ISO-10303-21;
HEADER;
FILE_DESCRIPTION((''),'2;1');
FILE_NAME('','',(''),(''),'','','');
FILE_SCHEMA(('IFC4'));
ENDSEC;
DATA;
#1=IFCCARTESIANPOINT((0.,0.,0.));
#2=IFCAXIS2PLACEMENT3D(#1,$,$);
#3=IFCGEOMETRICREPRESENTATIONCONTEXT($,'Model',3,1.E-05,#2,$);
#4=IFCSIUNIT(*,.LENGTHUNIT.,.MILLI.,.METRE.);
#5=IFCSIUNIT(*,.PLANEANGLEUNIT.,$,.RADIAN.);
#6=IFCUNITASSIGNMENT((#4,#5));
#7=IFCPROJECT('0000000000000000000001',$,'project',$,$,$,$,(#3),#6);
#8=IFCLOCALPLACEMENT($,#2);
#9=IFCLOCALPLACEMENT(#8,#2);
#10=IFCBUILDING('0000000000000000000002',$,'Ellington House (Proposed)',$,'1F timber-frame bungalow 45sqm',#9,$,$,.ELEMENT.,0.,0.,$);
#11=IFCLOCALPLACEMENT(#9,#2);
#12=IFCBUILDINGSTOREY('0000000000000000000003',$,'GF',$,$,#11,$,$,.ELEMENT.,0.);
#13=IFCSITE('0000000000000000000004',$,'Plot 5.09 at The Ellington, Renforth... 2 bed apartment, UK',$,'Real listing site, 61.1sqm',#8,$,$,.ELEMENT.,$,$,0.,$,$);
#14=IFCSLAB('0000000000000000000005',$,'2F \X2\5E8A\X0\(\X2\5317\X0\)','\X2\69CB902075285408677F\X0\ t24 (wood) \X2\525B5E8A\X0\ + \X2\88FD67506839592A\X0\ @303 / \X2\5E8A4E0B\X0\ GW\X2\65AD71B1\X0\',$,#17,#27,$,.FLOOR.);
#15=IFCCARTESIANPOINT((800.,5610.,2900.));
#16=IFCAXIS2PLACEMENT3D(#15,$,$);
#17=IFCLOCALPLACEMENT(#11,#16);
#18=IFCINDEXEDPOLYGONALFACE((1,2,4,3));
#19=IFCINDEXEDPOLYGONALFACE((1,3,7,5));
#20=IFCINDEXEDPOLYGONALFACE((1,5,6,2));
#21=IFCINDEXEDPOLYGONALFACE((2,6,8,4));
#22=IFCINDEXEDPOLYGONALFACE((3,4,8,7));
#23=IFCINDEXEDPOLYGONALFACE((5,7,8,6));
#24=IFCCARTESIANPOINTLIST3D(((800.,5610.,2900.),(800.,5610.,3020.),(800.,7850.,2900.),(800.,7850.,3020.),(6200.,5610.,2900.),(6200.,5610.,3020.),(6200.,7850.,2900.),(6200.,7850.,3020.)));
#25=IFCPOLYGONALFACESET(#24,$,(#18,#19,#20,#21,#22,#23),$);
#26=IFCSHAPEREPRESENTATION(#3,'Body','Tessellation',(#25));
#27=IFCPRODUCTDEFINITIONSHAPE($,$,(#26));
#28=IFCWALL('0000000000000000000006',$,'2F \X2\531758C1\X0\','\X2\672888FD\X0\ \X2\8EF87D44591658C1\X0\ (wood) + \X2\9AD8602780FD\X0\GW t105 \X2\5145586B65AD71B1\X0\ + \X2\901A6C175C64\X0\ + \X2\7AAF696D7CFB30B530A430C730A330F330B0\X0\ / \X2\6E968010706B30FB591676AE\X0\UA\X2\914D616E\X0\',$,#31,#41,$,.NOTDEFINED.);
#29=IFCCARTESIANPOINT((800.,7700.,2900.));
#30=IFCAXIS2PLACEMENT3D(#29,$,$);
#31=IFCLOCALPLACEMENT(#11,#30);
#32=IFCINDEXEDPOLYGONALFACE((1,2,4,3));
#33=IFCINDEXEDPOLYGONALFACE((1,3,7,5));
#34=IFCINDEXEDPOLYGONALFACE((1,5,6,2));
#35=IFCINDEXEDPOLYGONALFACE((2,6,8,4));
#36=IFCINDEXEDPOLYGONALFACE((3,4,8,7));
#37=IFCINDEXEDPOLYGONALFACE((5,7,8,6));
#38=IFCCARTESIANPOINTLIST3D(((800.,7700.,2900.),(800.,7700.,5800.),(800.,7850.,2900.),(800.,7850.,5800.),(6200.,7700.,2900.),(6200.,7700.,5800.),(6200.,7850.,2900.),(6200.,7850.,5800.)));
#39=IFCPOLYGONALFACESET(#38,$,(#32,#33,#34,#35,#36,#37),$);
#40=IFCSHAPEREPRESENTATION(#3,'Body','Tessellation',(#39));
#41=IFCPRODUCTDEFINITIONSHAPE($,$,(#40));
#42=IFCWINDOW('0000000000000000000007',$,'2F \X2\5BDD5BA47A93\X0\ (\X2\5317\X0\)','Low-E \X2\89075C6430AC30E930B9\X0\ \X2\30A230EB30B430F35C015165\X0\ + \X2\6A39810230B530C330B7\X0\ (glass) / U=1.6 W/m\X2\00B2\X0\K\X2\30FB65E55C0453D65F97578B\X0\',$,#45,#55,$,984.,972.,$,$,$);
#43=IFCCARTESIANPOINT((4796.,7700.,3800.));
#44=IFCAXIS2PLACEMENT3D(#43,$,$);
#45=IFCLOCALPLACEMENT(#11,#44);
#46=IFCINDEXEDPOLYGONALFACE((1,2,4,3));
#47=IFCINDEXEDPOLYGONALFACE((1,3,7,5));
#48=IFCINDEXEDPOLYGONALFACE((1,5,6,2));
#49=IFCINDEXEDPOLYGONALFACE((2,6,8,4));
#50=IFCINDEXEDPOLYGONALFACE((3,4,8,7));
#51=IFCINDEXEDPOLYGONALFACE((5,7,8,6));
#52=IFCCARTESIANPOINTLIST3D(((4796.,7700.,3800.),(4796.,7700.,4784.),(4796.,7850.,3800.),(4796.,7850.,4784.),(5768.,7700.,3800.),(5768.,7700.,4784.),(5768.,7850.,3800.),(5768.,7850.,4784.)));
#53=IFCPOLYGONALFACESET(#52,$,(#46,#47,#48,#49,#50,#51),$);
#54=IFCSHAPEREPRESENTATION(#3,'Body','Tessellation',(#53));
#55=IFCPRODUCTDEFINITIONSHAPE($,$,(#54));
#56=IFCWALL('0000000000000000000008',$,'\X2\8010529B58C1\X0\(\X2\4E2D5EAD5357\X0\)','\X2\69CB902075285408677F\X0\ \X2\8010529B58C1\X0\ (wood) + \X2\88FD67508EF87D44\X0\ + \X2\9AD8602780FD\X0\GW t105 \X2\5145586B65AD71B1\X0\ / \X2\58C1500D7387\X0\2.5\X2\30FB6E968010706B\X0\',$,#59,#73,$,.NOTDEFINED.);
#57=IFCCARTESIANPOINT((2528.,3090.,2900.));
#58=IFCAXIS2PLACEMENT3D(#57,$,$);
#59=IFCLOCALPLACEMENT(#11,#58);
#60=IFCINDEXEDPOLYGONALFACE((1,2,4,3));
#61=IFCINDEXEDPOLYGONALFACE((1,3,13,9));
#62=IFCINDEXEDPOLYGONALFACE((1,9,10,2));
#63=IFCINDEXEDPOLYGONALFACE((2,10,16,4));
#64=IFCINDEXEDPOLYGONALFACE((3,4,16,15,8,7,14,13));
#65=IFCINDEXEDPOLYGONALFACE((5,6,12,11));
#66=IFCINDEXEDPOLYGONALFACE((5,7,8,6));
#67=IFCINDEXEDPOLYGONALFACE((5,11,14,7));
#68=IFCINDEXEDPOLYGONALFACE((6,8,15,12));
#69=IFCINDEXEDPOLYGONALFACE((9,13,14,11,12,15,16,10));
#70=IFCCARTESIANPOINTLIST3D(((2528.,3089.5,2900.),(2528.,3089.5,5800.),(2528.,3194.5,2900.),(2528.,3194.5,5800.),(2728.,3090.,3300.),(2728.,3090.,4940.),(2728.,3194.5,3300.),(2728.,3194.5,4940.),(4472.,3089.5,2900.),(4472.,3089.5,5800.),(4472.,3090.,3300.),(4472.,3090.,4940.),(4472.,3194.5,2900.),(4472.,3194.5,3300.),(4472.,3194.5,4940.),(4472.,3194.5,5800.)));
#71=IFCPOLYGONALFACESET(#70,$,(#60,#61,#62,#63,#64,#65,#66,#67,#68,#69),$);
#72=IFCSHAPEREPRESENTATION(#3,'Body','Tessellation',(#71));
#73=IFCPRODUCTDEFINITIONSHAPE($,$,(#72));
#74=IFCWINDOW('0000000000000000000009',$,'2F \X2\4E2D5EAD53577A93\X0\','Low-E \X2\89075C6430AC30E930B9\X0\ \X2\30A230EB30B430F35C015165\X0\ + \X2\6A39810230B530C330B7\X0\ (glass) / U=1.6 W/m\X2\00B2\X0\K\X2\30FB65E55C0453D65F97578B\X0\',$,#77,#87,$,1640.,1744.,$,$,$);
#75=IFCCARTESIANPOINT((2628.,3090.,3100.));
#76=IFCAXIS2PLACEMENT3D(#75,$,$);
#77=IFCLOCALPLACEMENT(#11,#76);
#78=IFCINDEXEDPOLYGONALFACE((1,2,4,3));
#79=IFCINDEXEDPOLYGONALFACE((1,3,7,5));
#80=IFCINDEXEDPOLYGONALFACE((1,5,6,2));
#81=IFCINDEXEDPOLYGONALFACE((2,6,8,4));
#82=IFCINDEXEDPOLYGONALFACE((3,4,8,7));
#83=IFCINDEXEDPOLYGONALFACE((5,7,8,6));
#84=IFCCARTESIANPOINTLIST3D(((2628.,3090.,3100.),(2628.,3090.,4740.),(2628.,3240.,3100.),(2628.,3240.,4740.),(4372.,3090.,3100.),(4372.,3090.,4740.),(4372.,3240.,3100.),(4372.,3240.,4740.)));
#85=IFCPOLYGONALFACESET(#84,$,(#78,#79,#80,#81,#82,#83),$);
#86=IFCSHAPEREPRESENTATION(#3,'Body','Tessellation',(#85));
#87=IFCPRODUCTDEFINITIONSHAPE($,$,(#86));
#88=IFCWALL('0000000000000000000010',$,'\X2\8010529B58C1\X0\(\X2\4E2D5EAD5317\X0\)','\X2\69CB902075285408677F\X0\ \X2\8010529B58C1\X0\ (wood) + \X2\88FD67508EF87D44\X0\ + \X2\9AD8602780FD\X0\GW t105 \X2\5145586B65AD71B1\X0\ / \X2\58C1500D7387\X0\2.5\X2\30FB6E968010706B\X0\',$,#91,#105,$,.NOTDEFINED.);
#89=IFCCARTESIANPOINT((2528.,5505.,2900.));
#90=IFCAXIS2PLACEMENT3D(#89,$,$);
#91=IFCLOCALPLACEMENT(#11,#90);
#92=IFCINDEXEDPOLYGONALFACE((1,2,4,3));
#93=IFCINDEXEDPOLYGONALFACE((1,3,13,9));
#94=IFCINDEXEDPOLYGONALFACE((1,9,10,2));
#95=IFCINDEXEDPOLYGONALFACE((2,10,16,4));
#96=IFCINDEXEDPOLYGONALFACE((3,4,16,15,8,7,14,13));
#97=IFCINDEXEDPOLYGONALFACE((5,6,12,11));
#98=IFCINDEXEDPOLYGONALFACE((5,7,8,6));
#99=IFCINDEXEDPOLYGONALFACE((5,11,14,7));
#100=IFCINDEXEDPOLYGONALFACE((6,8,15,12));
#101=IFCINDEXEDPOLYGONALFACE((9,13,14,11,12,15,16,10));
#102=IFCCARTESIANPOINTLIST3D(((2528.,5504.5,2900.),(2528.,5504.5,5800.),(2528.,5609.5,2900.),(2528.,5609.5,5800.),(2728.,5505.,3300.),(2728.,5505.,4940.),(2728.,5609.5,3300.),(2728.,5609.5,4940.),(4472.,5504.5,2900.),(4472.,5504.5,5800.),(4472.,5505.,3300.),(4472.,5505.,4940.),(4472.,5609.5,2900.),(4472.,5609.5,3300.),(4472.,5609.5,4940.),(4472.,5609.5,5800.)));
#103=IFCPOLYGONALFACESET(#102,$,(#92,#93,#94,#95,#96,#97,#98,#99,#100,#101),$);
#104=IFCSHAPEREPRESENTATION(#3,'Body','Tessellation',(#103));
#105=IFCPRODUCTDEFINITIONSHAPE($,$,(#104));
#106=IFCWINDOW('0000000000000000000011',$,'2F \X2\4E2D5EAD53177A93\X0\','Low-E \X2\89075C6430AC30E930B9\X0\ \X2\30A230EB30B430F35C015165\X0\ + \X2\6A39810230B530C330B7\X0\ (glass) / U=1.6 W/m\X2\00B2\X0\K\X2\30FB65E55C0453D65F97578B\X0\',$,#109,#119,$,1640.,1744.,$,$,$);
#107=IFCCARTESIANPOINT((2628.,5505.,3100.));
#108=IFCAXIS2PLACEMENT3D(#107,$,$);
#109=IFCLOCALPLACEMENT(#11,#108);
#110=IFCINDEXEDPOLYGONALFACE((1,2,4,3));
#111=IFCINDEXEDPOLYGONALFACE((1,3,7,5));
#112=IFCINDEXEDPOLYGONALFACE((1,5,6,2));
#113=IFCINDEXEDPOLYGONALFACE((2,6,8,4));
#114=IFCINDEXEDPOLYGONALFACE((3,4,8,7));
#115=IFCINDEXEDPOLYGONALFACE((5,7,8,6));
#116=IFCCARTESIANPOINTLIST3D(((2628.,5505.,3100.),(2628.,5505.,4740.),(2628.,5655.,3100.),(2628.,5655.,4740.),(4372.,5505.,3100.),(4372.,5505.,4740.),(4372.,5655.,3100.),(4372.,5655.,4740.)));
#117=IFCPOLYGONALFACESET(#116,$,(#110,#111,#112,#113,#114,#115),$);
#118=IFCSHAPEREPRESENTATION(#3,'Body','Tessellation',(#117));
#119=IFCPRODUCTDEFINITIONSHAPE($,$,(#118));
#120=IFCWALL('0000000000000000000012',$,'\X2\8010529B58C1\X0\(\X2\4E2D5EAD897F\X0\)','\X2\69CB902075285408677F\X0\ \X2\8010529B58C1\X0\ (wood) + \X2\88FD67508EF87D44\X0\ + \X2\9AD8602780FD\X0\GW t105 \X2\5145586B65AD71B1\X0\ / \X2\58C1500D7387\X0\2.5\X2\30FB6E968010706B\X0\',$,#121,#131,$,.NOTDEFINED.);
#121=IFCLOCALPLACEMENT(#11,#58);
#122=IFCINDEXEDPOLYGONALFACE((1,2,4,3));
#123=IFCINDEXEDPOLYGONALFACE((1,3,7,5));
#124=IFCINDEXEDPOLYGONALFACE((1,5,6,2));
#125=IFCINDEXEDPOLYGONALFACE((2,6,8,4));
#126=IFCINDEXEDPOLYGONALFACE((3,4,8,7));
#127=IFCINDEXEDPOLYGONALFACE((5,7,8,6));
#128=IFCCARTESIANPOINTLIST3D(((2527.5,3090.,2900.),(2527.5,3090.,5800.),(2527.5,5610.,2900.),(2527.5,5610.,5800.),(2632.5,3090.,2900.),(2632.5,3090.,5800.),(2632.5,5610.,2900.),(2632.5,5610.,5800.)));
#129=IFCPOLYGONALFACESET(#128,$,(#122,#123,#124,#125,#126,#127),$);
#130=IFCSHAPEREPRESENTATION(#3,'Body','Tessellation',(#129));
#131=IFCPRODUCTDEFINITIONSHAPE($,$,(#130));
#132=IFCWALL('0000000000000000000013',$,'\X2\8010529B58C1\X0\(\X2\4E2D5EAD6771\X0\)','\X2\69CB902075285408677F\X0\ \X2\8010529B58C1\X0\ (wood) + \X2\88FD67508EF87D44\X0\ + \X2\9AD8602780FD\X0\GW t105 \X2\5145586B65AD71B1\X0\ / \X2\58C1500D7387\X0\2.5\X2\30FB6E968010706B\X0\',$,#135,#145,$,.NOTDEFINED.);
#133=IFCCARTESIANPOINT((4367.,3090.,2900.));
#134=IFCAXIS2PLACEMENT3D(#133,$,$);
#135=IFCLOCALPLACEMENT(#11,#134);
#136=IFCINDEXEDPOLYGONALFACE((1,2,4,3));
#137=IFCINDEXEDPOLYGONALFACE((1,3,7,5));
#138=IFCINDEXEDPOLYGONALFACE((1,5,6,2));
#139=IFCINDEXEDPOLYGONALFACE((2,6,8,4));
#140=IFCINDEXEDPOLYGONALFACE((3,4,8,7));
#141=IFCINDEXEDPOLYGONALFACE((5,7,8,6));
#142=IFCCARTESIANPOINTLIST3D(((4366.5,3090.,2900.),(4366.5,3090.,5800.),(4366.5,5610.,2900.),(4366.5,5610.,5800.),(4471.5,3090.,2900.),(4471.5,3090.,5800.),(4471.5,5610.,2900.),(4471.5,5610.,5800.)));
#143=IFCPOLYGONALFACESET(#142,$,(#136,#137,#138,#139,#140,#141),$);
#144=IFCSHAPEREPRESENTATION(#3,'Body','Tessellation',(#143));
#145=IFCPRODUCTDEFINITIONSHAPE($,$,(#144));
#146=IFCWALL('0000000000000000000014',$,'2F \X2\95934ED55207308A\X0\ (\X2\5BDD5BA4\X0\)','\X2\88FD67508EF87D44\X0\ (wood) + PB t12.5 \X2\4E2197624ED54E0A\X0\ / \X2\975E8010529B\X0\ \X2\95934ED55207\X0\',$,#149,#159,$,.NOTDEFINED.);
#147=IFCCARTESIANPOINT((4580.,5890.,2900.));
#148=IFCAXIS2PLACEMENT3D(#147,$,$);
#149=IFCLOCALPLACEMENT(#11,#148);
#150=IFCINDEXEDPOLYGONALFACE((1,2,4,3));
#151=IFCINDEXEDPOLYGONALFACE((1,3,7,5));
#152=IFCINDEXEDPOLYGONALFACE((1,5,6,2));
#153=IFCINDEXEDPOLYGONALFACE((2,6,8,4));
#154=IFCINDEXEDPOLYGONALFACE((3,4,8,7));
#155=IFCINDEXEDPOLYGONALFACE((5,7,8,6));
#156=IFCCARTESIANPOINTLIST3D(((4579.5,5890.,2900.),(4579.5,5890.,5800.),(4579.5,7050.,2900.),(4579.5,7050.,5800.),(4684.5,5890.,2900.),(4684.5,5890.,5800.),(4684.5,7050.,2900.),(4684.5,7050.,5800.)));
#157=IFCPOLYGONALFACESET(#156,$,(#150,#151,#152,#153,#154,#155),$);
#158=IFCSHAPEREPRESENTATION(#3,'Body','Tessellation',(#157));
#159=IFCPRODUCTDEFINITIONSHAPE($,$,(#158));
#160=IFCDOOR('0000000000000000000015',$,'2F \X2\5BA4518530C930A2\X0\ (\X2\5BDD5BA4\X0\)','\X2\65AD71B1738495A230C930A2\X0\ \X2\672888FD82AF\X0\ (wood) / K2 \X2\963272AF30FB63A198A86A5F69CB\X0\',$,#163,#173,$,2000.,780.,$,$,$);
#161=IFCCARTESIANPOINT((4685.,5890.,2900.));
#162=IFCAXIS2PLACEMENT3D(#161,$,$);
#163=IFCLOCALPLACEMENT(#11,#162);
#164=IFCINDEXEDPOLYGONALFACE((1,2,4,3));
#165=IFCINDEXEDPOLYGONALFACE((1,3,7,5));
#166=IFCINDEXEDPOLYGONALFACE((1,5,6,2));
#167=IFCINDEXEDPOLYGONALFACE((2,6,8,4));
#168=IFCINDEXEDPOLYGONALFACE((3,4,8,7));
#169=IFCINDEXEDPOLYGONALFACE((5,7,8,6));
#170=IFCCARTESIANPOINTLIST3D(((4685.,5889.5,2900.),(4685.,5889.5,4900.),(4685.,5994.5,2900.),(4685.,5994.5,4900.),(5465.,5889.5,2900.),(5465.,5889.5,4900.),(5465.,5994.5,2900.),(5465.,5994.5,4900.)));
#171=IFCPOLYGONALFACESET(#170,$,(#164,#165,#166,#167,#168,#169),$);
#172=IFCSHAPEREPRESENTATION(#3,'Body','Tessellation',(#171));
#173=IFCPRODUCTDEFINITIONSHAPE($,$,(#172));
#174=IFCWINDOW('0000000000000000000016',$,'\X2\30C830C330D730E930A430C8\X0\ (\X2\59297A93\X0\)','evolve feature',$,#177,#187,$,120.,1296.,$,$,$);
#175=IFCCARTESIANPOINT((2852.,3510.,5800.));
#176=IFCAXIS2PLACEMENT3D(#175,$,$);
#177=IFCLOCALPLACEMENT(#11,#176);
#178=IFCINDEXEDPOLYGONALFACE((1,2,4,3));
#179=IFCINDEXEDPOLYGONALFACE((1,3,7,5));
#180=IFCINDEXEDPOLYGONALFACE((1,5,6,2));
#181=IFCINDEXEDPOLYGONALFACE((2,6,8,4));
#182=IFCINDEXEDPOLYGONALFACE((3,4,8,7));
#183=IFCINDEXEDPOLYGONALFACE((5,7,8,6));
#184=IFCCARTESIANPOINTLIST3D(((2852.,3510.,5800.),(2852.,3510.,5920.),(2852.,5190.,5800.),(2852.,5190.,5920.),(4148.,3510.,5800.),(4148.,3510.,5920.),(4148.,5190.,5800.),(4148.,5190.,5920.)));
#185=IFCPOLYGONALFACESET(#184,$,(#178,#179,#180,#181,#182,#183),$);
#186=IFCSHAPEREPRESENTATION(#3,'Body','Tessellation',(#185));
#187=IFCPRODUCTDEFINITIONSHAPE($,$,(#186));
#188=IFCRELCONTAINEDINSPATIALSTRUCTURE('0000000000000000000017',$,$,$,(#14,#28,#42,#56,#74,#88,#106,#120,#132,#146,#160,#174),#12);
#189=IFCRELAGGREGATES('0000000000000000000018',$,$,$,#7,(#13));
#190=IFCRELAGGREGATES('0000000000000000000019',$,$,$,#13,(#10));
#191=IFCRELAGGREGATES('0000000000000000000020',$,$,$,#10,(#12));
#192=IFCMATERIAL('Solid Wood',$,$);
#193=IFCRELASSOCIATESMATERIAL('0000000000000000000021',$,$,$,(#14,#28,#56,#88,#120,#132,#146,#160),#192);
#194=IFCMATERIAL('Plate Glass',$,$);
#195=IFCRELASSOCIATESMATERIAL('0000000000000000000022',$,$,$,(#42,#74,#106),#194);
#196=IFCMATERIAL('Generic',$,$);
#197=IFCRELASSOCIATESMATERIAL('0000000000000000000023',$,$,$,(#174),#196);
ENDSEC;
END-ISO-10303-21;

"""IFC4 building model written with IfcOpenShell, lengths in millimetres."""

from ifc_helpers import new_model, si_unit, frame, frame_2d, origin, place, context, project, spatial, rectangle, extrude, material, element, fill, save


model = new_model("IFC4")

# Units and contexts
model_context = context("Model", 3, precision=1e-05, world=origin())
ifc_project = project(units=[si_unit("LENGTHUNIT", "METRE", prefix="MILLI"), si_unit("PLANEANGLEUNIT", "RADIAN")], contexts=[model_context])

# Site, building, storey
site_placement = place(None, origin())
site = spatial("IfcSite", under=ifc_project, at=site_placement, Name="Plot 5.09 at The Ellington, Renforth... 2 bed apartment, UK", ObjectType="Real listing site, 61.1sqm", CompositionType="ELEMENT", RefElevation=0.0)
building_placement = place(site_placement, origin())
building = spatial("IfcBuilding", under=site, at=building_placement, Name="Ellington House (Proposed)", ObjectType="1F timber-frame bungalow 45sqm", CompositionType="ELEMENT", ElevationOfRefHeight=0.0, ElevationOfTerrain=0.0)
storey_placement = place(building_placement, origin())
storey = spatial("IfcBuildingStorey", under=building, at=storey_placement, Name="GF", CompositionType="ELEMENT", Elevation=0.0)

# Slab
ifc_material_1 = material(Name="Solid Wood")
slab_placement = place(storey_placement, frame((800.0, 5610.0, 2900.0)))
element("IfcSlab", 1, at=slab_placement, inside=storey, material=ifc_material_1, Name="2F 床(北)", Description="構造用合板 t24 (wood) 剛床 + 製材根太 @303 / 床下 GW断熱", PredefinedType="FLOOR", context=model_context, shape_type="SweptSolid", body=[
    extrude(rectangle(XDim=5400.0, YDim=2240.0, at=frame_2d((2700.0, 1120.0))), frame((800.0, 5610.0, 2900.0)), (0.0, 0.0, 1.0), 120.0),
])

# Walls, openings, windows
wall_1_placement = place(storey_placement, frame((800.0, 7700.0, 2900.0)))
wall_1 = element("IfcWall", 2, at=wall_1_placement, inside=storey, material=ifc_material_1, Name="2F 北壁", Description="木製 軸組外壁 (wood) + 高性能GW t105 充填断熱 + 通気層 + 窯業系サイディング / 準耐火・外皮UA配慮", PredefinedType="NOTDEFINED", context=model_context, shape_type="SweptSolid", body=[
    extrude(rectangle(XDim=5400.0, YDim=150.0, at=frame_2d((2700.0, 75.0))), frame((800.0, 7700.0, 2900.0)), (0.0, 0.0, 1.0), 2900.0),
])
opening_1_placement = place(storey_placement, frame((4796.0, 7700.0, 3800.0)))
opening_1 = element("IfcOpeningElement", 3, at=opening_1_placement, cuts=wall_1, PredefinedType="NOTDEFINED", context=model_context, shape_type="SweptSolid", body=[
    extrude(rectangle(XDim=972.0, YDim=150.0, at=frame_2d((486.0, 75.0))), frame((4796.0, 7700.0, 3800.0)), (0.0, 0.0, 1.0), 984.0),
])
ifc_material_2 = material(Name="Plate Glass")
window_1_placement = place(storey_placement, frame((4796.0, 7700.0, 3800.0)))
window_1 = element("IfcWindow", 4, at=window_1_placement, inside=storey, material=ifc_material_2, Name="2F 寝室窓 (北)", Description="Low-E 複層ガラス アルゴン封入 + 樹脂サッシ (glass) / U=1.6 W/m²K・日射取得型", OverallHeight=984.0, OverallWidth=972.0, context=model_context, shape_type="SweptSolid", body=[
    extrude(rectangle(XDim=972.0, YDim=150.0, at=frame_2d((486.0, 75.0))), frame((4796.0, 7700.0, 3800.0)), (0.0, 0.0, 1.0), 984.0),
])
fill(opening_1, window_1)
wall_2_placement = place(storey_placement, frame((2528.0, 3090.0, 2900.0)))
wall_2 = element("IfcWall", 5, at=wall_2_placement, inside=storey, material=ifc_material_1, Name="耐力壁(中庭南)", Description="構造用合板 耐力壁 (wood) + 製材軸組 + 高性能GW t105 充填断熱 / 壁倍率2.5・準耐火", PredefinedType="NOTDEFINED", context=model_context, shape_type="SweptSolid", body=[
    extrude(rectangle(XDim=1944.0, YDim=105.0, at=frame_2d((972.0, 52.0))), frame((2528.0, 3090.0, 2900.0)), (0.0, 0.0, 1.0), 2900.0),
])
opening_2_placement = place(storey_placement, frame((2628.0, 3090.0, 3100.0)))
opening_2 = element("IfcOpeningElement", 6, at=opening_2_placement, cuts=wall_2, PredefinedType="NOTDEFINED", context=model_context, shape_type="SweptSolid", body=[
    extrude(rectangle(XDim=1744.0, YDim=150.0, at=frame_2d((872.0, 75.0))), frame((2628.0, 3090.0, 3100.0)), (0.0, 0.0, 1.0), 1640.0),
])
window_2_placement = place(storey_placement, frame((2628.0, 3090.0, 3100.0)))
window_2 = element("IfcWindow", 7, at=window_2_placement, inside=storey, material=ifc_material_2, Name="2F 中庭南窓", Description="Low-E 複層ガラス アルゴン封入 + 樹脂サッシ (glass) / U=1.6 W/m²K・日射取得型", OverallHeight=1640.0, OverallWidth=1744.0, context=model_context, shape_type="SweptSolid", body=[
    extrude(rectangle(XDim=1744.0, YDim=150.0, at=frame_2d((872.0, 75.0))), frame((2628.0, 3090.0, 3100.0)), (0.0, 0.0, 1.0), 1640.0),
])
fill(opening_2, window_2)
wall_3_placement = place(storey_placement, frame((2528.0, 5505.0, 2900.0)))
wall_3 = element("IfcWall", 8, at=wall_3_placement, inside=storey, material=ifc_material_1, Name="耐力壁(中庭北)", Description="構造用合板 耐力壁 (wood) + 製材軸組 + 高性能GW t105 充填断熱 / 壁倍率2.5・準耐火", PredefinedType="NOTDEFINED", context=model_context, shape_type="SweptSolid", body=[
    extrude(rectangle(XDim=1944.0, YDim=105.0, at=frame_2d((972.0, 52.0))), frame((2528.0, 5505.0, 2900.0)), (0.0, 0.0, 1.0), 2900.0),
])
opening_3_placement = place(storey_placement, frame((2628.0, 5505.0, 3100.0)))
opening_3 = element("IfcOpeningElement", 9, at=opening_3_placement, cuts=wall_3, PredefinedType="NOTDEFINED", context=model_context, shape_type="SweptSolid", body=[
    extrude(rectangle(XDim=1744.0, YDim=150.0, at=frame_2d((872.0, 75.0))), frame((2628.0, 5505.0, 3100.0)), (0.0, 0.0, 1.0), 1640.0),
])
window_3_placement = place(storey_placement, frame((2628.0, 5505.0, 3100.0)))
window_3 = element("IfcWindow", 10, at=window_3_placement, inside=storey, material=ifc_material_2, Name="2F 中庭北窓", Description="Low-E 複層ガラス アルゴン封入 + 樹脂サッシ (glass) / U=1.6 W/m²K・日射取得型", OverallHeight=1640.0, OverallWidth=1744.0, context=model_context, shape_type="SweptSolid", body=[
    extrude(rectangle(XDim=1744.0, YDim=150.0, at=frame_2d((872.0, 75.0))), frame((2628.0, 5505.0, 3100.0)), (0.0, 0.0, 1.0), 1640.0),
])
fill(opening_3, window_3)

# Walls
wall_4_placement = place(storey_placement, frame((2528.0, 3090.0, 2900.0)))
element("IfcWall", 11, at=wall_4_placement, inside=storey, material=ifc_material_1, Name="耐力壁(中庭西)", Description="構造用合板 耐力壁 (wood) + 製材軸組 + 高性能GW t105 充填断熱 / 壁倍率2.5・準耐火", PredefinedType="NOTDEFINED", context=model_context, shape_type="SweptSolid", body=[
    extrude(rectangle(XDim=105.0, YDim=2520.0, at=frame_2d((52.0, 1260.0))), frame((2528.0, 3090.0, 2900.0)), (0.0, 0.0, 1.0), 2900.0),
])
wall_5_placement = place(storey_placement, frame((4367.0, 3090.0, 2900.0)))
element("IfcWall", 12, at=wall_5_placement, inside=storey, material=ifc_material_1, Name="耐力壁(中庭東)", Description="構造用合板 耐力壁 (wood) + 製材軸組 + 高性能GW t105 充填断熱 / 壁倍率2.5・準耐火", PredefinedType="NOTDEFINED", context=model_context, shape_type="SweptSolid", body=[
    extrude(rectangle(XDim=105.0, YDim=2520.0, at=frame_2d((52.0, 1260.0))), frame((4367.0, 3090.0, 2900.0)), (0.0, 0.0, 1.0), 2900.0),
])
wall_6_placement = place(storey_placement, frame((4580.0, 5890.0, 2900.0)))
element("IfcWall", 13, at=wall_6_placement, inside=storey, material=ifc_material_1, Name="2F 間仕切り (寝室)", Description="製材軸組 (wood) + PB t12.5 両面仕上 / 非耐力 間仕切", PredefinedType="NOTDEFINED", context=model_context, shape_type="SweptSolid", body=[
    extrude(rectangle(XDim=105.0, YDim=1160.0, at=frame_2d((52.0, 580.0))), frame((4580.0, 5890.0, 2900.0)), (0.0, 0.0, 1.0), 2900.0),
])

# Door
door_placement = place(storey_placement, frame((4685.0, 5890.0, 2900.0)))
element("IfcDoor", 14, at=door_placement, inside=storey, material=ifc_material_1, Name="2F 室内ドア (寝室)", Description="断熱玄関ドア 木製芯 (wood) / K2 防犯・採風機構", OverallHeight=2000.0, OverallWidth=780.0, context=model_context, shape_type="SweptSolid", body=[
    extrude(rectangle(XDim=780.0, YDim=105.0, at=frame_2d((390.0, 52.0))), frame((4685.0, 5890.0, 2900.0)), (0.0, 0.0, 1.0), 2000.0),
])

# Window
ifc_material_3 = material(Name="Generic")
window_4_placement = place(storey_placement, frame((2852.0, 3510.0, 5800.0)))
element("IfcWindow", 15, at=window_4_placement, inside=storey, material=ifc_material_3, Name="トップライト (天窓)", Description="evolve feature", OverallHeight=120.0, OverallWidth=1296.0, context=model_context, shape_type="SweptSolid", body=[
    extrude(rectangle(XDim=1296.0, YDim=1680.0, at=frame_2d((648.0, 840.0))), frame((2852.0, 3510.0, 5800.0)), (0.0, 0.0, 1.0), 120.0),
])

save(model, "model.ifc")
